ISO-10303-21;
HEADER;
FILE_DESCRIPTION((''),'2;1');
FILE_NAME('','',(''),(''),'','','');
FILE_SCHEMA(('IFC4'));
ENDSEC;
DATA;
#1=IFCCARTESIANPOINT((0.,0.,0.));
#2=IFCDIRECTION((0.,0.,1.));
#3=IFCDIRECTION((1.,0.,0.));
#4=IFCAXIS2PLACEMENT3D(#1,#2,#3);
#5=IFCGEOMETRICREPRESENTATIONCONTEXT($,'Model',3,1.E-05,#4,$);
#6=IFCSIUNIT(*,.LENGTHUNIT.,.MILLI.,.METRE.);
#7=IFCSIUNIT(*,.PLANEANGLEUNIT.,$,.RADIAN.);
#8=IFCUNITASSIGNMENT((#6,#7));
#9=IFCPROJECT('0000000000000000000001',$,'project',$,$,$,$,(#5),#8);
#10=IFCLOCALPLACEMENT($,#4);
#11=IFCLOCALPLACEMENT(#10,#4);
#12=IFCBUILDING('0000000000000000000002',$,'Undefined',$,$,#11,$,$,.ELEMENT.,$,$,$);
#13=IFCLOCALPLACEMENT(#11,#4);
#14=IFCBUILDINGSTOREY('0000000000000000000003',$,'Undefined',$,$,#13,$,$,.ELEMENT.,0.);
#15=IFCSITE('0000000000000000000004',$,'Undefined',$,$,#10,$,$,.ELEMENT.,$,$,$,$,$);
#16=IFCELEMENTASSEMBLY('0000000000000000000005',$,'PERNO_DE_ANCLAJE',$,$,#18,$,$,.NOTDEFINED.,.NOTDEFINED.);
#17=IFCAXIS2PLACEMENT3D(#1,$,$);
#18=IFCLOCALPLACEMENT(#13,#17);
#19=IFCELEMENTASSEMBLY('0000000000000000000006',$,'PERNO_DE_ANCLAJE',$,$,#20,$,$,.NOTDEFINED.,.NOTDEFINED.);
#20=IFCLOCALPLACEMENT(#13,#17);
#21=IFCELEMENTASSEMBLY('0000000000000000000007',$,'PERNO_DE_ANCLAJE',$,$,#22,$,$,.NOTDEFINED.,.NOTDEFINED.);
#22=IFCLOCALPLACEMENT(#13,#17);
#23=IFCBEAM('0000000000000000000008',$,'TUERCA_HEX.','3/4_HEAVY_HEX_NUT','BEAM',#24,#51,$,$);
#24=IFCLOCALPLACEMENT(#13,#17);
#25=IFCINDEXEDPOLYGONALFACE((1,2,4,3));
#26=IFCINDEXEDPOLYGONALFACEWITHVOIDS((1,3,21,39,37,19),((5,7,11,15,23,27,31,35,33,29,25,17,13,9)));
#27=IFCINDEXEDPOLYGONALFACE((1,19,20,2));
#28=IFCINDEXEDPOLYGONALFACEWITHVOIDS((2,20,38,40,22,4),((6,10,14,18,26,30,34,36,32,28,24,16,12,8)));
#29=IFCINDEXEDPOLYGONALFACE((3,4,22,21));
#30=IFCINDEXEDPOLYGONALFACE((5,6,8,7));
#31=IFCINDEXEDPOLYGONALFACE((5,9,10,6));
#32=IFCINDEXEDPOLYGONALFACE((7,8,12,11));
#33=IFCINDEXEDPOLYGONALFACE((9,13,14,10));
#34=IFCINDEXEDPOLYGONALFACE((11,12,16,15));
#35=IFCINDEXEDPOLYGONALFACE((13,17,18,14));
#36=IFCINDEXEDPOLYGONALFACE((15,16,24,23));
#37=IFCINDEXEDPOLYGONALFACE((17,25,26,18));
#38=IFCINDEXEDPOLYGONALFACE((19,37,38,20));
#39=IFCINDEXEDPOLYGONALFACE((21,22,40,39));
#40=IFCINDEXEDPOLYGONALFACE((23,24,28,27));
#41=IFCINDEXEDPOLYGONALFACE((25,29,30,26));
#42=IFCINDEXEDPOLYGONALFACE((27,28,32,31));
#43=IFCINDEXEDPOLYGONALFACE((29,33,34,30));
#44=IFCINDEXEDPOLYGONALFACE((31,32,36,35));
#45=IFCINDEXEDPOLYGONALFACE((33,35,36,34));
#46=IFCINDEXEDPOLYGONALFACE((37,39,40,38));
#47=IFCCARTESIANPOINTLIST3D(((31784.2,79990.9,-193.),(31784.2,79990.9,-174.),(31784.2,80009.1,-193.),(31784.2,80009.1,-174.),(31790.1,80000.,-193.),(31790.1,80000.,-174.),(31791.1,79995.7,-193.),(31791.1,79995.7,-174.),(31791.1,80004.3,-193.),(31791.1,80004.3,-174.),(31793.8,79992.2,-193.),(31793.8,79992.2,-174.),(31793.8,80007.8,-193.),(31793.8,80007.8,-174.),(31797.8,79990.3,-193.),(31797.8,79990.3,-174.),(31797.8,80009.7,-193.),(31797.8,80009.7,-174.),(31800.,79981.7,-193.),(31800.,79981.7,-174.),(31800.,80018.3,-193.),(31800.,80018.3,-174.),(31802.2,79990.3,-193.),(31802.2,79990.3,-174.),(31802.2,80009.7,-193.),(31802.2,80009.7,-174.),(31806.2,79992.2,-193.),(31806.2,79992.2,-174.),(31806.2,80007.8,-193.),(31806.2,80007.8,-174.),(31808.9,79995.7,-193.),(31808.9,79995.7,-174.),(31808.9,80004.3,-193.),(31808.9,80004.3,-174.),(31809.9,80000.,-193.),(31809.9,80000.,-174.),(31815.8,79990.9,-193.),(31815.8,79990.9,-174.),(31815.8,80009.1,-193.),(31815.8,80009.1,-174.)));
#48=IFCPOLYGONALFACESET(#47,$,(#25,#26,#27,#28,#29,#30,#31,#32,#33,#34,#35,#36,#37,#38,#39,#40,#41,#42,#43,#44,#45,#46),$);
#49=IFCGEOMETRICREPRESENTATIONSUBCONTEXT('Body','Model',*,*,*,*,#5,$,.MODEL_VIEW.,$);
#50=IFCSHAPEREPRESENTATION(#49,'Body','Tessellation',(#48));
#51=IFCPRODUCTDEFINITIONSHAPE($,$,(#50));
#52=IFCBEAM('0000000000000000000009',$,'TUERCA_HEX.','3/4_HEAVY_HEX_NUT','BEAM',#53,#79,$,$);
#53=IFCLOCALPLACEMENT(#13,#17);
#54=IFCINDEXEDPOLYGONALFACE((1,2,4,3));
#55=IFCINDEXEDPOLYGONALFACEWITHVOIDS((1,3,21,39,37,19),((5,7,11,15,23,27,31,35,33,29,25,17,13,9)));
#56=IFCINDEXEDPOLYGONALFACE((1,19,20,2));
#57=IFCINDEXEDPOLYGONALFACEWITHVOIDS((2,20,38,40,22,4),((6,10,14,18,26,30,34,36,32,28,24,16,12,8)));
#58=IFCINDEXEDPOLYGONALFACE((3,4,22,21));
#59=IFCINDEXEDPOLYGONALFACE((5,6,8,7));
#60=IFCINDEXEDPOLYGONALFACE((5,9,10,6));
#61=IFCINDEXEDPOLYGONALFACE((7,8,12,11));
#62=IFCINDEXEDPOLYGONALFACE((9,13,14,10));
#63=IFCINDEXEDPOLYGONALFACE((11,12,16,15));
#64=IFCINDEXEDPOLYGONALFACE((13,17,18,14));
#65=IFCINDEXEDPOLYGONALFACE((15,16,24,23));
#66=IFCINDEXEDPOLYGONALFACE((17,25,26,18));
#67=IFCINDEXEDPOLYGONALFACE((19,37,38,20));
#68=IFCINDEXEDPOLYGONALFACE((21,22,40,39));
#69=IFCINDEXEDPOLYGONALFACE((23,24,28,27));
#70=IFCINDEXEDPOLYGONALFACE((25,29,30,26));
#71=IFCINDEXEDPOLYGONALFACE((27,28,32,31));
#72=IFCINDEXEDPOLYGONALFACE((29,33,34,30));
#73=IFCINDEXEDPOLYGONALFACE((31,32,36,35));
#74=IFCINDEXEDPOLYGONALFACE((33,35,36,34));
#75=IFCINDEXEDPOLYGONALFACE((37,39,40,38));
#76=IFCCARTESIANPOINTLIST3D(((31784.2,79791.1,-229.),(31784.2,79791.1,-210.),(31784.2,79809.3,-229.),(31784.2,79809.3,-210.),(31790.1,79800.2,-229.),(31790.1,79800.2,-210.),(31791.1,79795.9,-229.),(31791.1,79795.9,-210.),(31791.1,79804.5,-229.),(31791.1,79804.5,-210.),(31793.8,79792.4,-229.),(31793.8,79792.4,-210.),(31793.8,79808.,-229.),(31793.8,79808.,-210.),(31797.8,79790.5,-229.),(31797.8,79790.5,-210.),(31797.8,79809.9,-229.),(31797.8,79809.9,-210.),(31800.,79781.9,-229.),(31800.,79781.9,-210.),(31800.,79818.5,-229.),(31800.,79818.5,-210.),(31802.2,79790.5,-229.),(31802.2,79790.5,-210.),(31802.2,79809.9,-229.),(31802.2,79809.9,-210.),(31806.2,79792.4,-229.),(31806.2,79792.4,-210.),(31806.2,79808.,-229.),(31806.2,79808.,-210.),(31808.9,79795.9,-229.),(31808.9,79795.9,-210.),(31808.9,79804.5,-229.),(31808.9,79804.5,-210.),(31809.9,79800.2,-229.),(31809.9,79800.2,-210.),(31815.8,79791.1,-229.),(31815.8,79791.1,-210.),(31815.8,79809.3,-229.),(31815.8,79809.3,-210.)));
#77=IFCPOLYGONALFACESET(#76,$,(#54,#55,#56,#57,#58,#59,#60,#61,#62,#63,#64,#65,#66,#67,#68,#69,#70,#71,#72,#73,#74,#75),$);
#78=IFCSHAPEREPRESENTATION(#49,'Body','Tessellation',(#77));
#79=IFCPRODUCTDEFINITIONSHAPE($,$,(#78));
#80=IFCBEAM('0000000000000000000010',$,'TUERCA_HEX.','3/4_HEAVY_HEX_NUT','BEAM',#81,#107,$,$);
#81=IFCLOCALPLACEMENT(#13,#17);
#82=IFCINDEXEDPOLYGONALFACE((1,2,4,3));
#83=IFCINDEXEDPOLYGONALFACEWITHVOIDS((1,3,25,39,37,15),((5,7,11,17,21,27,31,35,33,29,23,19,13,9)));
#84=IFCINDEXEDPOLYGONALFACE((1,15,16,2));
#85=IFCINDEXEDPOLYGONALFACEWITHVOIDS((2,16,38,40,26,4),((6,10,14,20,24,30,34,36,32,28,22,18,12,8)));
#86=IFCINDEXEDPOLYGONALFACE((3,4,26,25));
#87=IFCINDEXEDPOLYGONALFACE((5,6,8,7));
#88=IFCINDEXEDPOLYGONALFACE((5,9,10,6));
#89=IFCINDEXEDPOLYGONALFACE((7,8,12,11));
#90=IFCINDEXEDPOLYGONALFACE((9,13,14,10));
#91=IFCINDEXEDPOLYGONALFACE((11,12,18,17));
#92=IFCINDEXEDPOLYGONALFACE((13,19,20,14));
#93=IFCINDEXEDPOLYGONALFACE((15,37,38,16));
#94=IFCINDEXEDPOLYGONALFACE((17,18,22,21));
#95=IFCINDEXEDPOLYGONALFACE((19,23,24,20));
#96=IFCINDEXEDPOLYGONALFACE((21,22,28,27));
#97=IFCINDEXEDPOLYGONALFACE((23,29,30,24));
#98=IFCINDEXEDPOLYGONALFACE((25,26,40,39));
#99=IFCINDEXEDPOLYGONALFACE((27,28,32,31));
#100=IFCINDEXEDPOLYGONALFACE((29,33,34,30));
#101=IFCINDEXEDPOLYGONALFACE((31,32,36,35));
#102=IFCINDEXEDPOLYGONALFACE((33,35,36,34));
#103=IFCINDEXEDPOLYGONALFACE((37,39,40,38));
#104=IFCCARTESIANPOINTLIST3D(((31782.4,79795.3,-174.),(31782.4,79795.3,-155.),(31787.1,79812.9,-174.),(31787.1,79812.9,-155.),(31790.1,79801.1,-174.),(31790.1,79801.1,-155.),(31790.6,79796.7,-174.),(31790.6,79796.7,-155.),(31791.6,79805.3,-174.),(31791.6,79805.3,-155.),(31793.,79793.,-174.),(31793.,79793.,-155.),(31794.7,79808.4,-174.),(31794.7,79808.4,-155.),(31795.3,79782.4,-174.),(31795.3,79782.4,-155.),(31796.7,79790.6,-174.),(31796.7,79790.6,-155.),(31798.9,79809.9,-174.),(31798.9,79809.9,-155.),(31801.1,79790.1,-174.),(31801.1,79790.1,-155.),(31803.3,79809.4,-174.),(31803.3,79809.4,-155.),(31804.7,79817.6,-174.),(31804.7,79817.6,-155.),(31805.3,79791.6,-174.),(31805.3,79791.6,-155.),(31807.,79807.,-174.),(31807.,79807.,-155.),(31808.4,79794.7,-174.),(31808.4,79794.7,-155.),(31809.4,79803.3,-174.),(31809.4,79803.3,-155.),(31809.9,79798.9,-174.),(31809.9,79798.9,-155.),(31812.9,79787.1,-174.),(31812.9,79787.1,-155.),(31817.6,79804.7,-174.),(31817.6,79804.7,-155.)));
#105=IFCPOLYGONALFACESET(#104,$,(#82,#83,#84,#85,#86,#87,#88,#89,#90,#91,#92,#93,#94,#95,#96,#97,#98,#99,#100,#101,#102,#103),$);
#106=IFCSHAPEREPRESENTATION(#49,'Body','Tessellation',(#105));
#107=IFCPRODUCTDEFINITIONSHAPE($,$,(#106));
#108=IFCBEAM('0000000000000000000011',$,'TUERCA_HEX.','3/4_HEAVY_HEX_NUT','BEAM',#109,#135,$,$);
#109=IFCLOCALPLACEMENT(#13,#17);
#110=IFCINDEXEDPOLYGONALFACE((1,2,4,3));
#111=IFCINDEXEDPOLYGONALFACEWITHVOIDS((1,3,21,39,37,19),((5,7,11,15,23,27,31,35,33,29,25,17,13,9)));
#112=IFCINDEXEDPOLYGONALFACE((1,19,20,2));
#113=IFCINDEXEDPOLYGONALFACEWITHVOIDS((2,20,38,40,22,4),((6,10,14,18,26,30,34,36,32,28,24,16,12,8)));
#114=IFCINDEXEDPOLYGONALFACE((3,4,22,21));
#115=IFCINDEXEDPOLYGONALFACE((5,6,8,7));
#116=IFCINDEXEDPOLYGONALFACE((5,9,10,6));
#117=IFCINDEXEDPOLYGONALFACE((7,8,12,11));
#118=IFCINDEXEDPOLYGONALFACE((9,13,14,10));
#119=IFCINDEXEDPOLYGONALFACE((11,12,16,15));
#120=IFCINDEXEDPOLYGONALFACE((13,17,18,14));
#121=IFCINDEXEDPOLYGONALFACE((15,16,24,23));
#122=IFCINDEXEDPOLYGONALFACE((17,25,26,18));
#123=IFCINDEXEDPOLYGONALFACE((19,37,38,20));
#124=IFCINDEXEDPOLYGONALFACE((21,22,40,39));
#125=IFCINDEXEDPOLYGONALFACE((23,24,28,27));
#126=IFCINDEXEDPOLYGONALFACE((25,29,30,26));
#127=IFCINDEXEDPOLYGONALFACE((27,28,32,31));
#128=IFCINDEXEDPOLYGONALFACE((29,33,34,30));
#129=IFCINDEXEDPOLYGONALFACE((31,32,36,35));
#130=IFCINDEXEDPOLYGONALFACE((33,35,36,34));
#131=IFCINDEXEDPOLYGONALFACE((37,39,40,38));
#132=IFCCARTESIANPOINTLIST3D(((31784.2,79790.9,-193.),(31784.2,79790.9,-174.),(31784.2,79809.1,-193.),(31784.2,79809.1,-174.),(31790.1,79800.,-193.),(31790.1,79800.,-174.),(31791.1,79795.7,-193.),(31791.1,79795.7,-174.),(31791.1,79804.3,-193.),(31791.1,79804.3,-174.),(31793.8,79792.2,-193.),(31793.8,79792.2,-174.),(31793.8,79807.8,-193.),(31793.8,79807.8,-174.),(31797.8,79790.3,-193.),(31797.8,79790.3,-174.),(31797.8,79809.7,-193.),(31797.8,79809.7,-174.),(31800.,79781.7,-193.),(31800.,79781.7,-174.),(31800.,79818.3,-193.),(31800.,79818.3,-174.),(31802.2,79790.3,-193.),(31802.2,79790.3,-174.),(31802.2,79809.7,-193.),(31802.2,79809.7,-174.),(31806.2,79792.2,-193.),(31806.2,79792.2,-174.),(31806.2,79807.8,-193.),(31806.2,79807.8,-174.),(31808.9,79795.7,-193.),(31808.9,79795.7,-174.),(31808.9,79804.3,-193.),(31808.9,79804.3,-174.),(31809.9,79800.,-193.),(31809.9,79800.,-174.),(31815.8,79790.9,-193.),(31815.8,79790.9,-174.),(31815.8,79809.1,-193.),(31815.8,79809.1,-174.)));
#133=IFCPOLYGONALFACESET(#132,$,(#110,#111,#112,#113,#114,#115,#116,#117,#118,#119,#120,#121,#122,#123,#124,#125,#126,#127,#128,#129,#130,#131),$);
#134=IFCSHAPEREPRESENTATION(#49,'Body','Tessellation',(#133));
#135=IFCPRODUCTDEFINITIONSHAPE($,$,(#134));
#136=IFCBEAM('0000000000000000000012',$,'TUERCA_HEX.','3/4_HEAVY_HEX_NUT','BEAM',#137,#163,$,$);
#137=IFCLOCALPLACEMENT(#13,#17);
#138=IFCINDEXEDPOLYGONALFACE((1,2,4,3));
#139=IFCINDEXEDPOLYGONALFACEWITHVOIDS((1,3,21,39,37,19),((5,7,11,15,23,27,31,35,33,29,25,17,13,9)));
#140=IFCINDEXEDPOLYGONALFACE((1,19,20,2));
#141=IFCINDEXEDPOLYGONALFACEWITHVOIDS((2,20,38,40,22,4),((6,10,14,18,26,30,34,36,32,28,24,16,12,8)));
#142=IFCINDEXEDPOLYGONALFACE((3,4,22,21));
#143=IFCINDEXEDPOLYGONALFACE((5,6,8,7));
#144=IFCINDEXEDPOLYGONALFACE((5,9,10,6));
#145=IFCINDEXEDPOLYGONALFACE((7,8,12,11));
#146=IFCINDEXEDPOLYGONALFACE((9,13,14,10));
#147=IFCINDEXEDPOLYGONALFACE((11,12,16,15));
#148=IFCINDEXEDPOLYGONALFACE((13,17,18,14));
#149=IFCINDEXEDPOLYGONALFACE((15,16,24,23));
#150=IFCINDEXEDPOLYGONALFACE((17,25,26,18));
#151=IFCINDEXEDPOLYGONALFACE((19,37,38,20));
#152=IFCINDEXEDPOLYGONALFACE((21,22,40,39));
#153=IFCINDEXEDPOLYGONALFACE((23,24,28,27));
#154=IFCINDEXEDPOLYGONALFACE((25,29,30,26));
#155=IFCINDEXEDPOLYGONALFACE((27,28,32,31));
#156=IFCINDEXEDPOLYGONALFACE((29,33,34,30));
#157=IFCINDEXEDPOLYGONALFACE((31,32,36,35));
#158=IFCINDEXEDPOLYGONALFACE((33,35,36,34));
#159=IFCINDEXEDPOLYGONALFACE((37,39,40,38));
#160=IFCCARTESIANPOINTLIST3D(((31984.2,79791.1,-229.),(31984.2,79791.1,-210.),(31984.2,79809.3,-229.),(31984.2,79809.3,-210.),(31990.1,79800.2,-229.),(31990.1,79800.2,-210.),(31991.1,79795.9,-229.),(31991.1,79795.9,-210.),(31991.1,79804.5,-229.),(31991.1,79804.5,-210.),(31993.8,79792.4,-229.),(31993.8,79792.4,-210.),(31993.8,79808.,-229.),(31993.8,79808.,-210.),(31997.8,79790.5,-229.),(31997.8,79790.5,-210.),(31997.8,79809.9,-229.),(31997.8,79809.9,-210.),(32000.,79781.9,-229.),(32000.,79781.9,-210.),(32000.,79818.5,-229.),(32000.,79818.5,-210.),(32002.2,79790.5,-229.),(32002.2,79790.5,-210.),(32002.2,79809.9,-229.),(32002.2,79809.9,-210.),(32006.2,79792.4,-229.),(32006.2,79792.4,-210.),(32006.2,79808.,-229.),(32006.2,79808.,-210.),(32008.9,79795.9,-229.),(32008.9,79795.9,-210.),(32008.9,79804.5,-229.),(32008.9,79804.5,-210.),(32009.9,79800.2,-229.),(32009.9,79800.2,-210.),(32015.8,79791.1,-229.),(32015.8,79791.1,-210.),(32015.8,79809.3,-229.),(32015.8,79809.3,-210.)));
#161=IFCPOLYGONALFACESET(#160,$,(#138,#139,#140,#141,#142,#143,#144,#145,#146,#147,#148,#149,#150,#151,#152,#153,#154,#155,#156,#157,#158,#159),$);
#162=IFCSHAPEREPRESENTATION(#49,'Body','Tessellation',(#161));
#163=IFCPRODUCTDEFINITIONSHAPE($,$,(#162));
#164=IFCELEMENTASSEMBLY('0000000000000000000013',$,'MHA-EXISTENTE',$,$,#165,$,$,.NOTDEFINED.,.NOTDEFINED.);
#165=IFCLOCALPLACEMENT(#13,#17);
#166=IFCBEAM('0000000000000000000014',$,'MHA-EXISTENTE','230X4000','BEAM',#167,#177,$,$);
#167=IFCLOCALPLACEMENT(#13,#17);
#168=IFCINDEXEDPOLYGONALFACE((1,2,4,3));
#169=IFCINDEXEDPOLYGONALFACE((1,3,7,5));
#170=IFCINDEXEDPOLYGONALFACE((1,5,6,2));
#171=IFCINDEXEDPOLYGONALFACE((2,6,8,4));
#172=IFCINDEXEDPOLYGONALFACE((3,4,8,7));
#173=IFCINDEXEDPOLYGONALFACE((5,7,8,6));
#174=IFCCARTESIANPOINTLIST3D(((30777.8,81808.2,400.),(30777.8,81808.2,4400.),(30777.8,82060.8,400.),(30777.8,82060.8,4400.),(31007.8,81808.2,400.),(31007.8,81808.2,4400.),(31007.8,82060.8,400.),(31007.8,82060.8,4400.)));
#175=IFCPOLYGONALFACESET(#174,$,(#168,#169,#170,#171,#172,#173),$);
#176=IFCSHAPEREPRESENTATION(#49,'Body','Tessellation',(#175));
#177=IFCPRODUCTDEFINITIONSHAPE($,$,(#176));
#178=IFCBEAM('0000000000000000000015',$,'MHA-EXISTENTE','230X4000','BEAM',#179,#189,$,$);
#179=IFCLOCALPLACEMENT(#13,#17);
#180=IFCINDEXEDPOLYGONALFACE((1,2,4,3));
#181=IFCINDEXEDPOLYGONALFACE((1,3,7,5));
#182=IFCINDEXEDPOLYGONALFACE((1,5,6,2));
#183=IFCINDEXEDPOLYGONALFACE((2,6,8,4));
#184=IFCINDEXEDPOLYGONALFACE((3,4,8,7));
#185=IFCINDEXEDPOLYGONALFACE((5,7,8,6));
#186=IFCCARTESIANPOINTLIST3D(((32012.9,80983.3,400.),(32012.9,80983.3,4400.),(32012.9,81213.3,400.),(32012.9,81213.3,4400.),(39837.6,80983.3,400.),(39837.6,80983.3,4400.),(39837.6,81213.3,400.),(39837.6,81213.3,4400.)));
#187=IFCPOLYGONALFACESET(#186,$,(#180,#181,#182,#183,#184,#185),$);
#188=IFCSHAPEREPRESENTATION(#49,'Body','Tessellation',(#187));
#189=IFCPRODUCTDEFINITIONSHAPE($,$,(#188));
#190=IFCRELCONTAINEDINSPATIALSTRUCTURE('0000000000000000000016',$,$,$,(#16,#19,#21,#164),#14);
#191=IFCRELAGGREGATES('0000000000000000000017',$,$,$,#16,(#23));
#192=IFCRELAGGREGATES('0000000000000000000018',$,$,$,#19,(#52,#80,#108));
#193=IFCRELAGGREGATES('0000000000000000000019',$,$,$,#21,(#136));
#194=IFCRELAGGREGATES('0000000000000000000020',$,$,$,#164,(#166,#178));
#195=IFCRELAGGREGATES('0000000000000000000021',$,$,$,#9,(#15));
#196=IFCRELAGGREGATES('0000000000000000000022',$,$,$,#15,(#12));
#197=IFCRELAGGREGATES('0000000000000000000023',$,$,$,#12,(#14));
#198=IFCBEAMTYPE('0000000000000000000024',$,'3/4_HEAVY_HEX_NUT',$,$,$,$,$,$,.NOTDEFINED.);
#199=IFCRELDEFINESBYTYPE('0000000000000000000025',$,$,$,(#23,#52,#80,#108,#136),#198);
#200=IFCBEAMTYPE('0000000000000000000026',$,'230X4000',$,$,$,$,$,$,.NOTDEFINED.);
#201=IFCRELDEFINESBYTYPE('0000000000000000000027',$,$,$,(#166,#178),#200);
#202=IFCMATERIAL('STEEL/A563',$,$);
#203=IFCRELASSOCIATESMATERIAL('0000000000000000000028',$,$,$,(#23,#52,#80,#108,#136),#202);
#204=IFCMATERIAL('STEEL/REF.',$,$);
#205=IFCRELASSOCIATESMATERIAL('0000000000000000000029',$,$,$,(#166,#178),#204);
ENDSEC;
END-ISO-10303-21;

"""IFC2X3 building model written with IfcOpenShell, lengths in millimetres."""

from ifc_helpers import new_model, si_unit, frame, origin_with_axes, origin_2d_with_axis, place, context, subcontext, project, spatial, polyline, rectangle, outline, extrude, material, type_object, element, aggregate, save


model = new_model("IFC2X3")

# Units and contexts
model_context = context("Model", 3, precision=1e-05, world=origin_with_axes())
body_context = subcontext(model_context, "Body", "Model", "MODEL_VIEW")
ifc_project = project(units=[si_unit("LENGTHUNIT", "METRE", prefix="MILLI"), si_unit("PLANEANGLEUNIT", "RADIAN")], contexts=[model_context])

# Site, building, storey
site_placement = place(None, origin_with_axes())
site = spatial("IfcSite", under=ifc_project, at=site_placement, Name="Undefined", CompositionType="ELEMENT")
building_placement = place(site_placement, origin_with_axes())
building = spatial("IfcBuilding", under=site, at=building_placement, Name="Undefined", CompositionType="ELEMENT")
storey_placement = place(building_placement, origin_with_axes())
storey = spatial("IfcBuildingStorey", under=building, at=storey_placement, Name="Undefined", CompositionType="ELEMENT", Elevation=0.0)

# Element assemblies
ifc_material_1 = material(Name="STEEL/A563")
assembly_1_placement = place(storey_placement, origin_with_axes())
assembly_1 = element("IfcElementAssembly", 1, at=assembly_1_placement, inside=storey, Name="PERNO_DE_ANCLAJE", AssemblyPlace="NOTDEFINED", PredefinedType="NOTDEFINED")
assembly_2_placement = place(storey_placement, origin_with_axes())
assembly_2 = element("IfcElementAssembly", 2, at=assembly_2_placement, inside=storey, Name="PERNO_DE_ANCLAJE", AssemblyPlace="NOTDEFINED", PredefinedType="NOTDEFINED")
assembly_3_placement = place(storey_placement, origin_with_axes())
assembly_3 = element("IfcElementAssembly", 3, at=assembly_3_placement, inside=storey, Name="PERNO_DE_ANCLAJE", AssemblyPlace="NOTDEFINED", PredefinedType="NOTDEFINED")

# Beams
beam_type_1 = type_object("IfcBeamType", Name="3/4_HEAVY_HEX_NUT", PredefinedType="NOTDEFINED")
beam_1_placement = place(assembly_1_placement, frame((31800.0, 80000.0, -174.0), z_axis=(1.0, 0.0, 0.0), x_axis=(0.0, 0.0, -1.0)))
beam_1 = element("IfcBeam", 4, at=beam_1_placement, type_object=beam_type_1, material=ifc_material_1, Name="TUERCA_HEX.", Description="3/4_HEAVY_HEX_NUT", ObjectType="BEAM", context=body_context, shape_type="SweptSolid", body=[
    extrude(outline(polyline([(-9.1, -15.8), (-18.3, 0.0), (-9.1, 15.8), (9.1, 15.8), (18.3, 0.0), (9.1, -15.8), (-9.1, -15.8)]), holes=[polyline([(7.8, 6.2), (4.3, 8.9), (0.0, 9.9), (-4.3, 8.9), (-7.8, 6.2), (-9.7, 2.2), (-9.7, -2.2), (-7.8, -6.2), (-4.3, -8.9), (0.0, -9.9), (4.3, -8.9), (7.8, -6.2), (9.7, -2.2), (9.7, 2.2), (7.8, 6.2)])]), frame((19.0, 0.0, 0.0), z_axis=(-1.0, 0.0, 0.0), x_axis=(0.0, -1.0, 0.0)), (0.0, 0.0, 1.0), 19.0),
])
aggregate(assembly_1, [beam_1])
beam_2_placement = place(assembly_2_placement, frame((31800.0, 79800.2, -210.0), z_axis=(1.0, 0.0, 0.0), x_axis=(0.0, 0.0, -1.0)))
beam_2 = element("IfcBeam", 5, at=beam_2_placement, type_object=beam_type_1, material=ifc_material_1, Name="TUERCA_HEX.", Description="3/4_HEAVY_HEX_NUT", ObjectType="BEAM", context=body_context, shape_type="SweptSolid", body=[
    extrude(outline(polyline([(-9.1, -15.8), (-18.3, 0.0), (-9.1, 15.8), (9.1, 15.8), (18.3, 0.0), (9.1, -15.8), (-9.1, -15.8)]), holes=[polyline([(7.8, 6.2), (4.3, 8.9), (0.0, 9.9), (-4.3, 8.9), (-7.8, 6.2), (-9.7, 2.2), (-9.7, -2.2), (-7.8, -6.2), (-4.3, -8.9), (0.0, -9.9), (4.3, -8.9), (7.8, -6.2), (9.7, -2.2), (9.7, 2.2), (7.8, 6.2)])]), frame((19.0, 0.0, 0.0), z_axis=(-1.0, 0.0, 0.0), x_axis=(0.0, -1.0, 0.0)), (0.0, 0.0, 1.0), 19.0),
])
beam_3_placement = place(assembly_2_placement, frame((31800.0, 79800.0, -155.0), z_axis=(0.707107, 0.707107, 0.0), x_axis=(0.0, 0.0, -1.0)))
beam_3 = element("IfcBeam", 6, at=beam_3_placement, type_object=beam_type_1, material=ifc_material_1, Name="TUERCA_HEX.", Description="3/4_HEAVY_HEX_NUT", ObjectType="BEAM", context=body_context, shape_type="SweptSolid", body=[
    extrude(outline(polyline([(-9.1, -15.8), (-18.3, 0.0), (-9.1, 15.8), (9.1, 15.8), (18.3, 0.0), (9.1, -15.8), (-9.1, -15.8)]), holes=[polyline([(7.8, 6.2), (4.3, 8.9), (0.0, 9.9), (-4.3, 8.9), (-7.8, 6.2), (-9.7, 2.2), (-9.7, -2.2), (-7.8, -6.2), (-4.3, -8.9), (0.0, -9.9), (4.3, -8.9), (7.8, -6.2), (9.7, -2.2), (9.7, 2.2), (7.8, 6.2)])]), frame((19.0, 0.0, 0.0), z_axis=(-1.0, 0.0, 0.0), x_axis=(0.0, -1.0, 0.0)), (0.0, 0.0, 1.0), 19.0),
])
beam_4_placement = place(assembly_2_placement, frame((31800.0, 79800.0, -174.0), z_axis=(1.0, 0.0, 0.0), x_axis=(0.0, 0.0, -1.0)))
beam_4 = element("IfcBeam", 7, at=beam_4_placement, type_object=beam_type_1, material=ifc_material_1, Name="TUERCA_HEX.", Description="3/4_HEAVY_HEX_NUT", ObjectType="BEAM", context=body_context, shape_type="SweptSolid", body=[
    extrude(outline(polyline([(-9.1, -15.8), (-18.3, 0.0), (-9.1, 15.8), (9.1, 15.8), (18.3, 0.0), (9.1, -15.8), (-9.1, -15.8)]), holes=[polyline([(7.8, 6.2), (4.3, 8.9), (0.0, 9.9), (-4.3, 8.9), (-7.8, 6.2), (-9.7, 2.2), (-9.7, -2.2), (-7.8, -6.2), (-4.3, -8.9), (0.0, -9.9), (4.3, -8.9), (7.8, -6.2), (9.7, -2.2), (9.7, 2.2), (7.8, 6.2)])]), frame((19.0, 0.0, 0.0), z_axis=(-1.0, 0.0, 0.0), x_axis=(0.0, -1.0, 0.0)), (0.0, 0.0, 1.0), 19.0),
])
aggregate(assembly_2, [beam_2, beam_3, beam_4])
beam_5_placement = place(assembly_3_placement, frame((32000.0, 79800.2, -210.0), z_axis=(1.0, 0.0, 0.0), x_axis=(0.0, 0.0, -1.0)))
beam_5 = element("IfcBeam", 8, at=beam_5_placement, type_object=beam_type_1, material=ifc_material_1, Name="TUERCA_HEX.", Description="3/4_HEAVY_HEX_NUT", ObjectType="BEAM", context=body_context, shape_type="SweptSolid", body=[
    extrude(outline(polyline([(-9.1, -15.8), (-18.3, 0.0), (-9.1, 15.8), (9.1, 15.8), (18.3, 0.0), (9.1, -15.8), (-9.1, -15.8)]), holes=[polyline([(7.8, 6.2), (4.3, 8.9), (0.0, 9.9), (-4.3, 8.9), (-7.8, 6.2), (-9.7, 2.2), (-9.7, -2.2), (-7.8, -6.2), (-4.3, -8.9), (0.0, -9.9), (4.3, -8.9), (7.8, -6.2), (9.7, -2.2), (9.7, 2.2), (7.8, 6.2)])]), frame((19.0, 0.0, 0.0), z_axis=(-1.0, 0.0, 0.0), x_axis=(0.0, -1.0, 0.0)), (0.0, 0.0, 1.0), 19.0),
])
aggregate(assembly_3, [beam_5])

# Shared definitions
ifc_material_2 = material(Name="STEEL/REF.")

# Element assembly, beams
assembly_4_placement = place(storey_placement, origin_with_axes())
assembly_4 = element("IfcElementAssembly", 9, at=assembly_4_placement, inside=storey, Name="MHA-EXISTENTE", AssemblyPlace="NOTDEFINED", PredefinedType="NOTDEFINED")
beam_type_2 = type_object("IfcBeamType", Name="230X4000", PredefinedType="NOTDEFINED")
beam_6_placement = place(assembly_4_placement, frame((30892.8, 82060.8, 2400.0), z_axis=(1.0, -0.000049, 0.0), x_axis=(-0.000049, -1.0, 0.0)))
beam_6 = element("IfcBeam", 10, at=beam_6_placement, type_object=beam_type_2, material=ifc_material_2, Name="MHA-EXISTENTE", Description="230X4000", ObjectType="BEAM", context=body_context, shape_type="SweptSolid", body=[
    extrude(rectangle(XDim=4000.0, YDim=230.0, at=origin_2d_with_axis()), frame((252.7, 0.0, 0.0), z_axis=(-1.0, 0.0, 0.0), x_axis=(0.0, -1.0, 0.0)), (0.0, 0.0, 1.0), 252.7),
])
beam_7_placement = place(assembly_4_placement, frame((32012.9, 81098.3, 2400.0), z_axis=(0.0, 1.0, 0.0), x_axis=(1.0, 0.0, 0.0)))
beam_7 = element("IfcBeam", 11, at=beam_7_placement, type_object=beam_type_2, material=ifc_material_2, Name="MHA-EXISTENTE", Description="230X4000", ObjectType="BEAM", context=body_context, shape_type="SweptSolid", body=[
    extrude(rectangle(XDim=4000.0, YDim=230.0, at=origin_2d_with_axis()), frame((7824.7, 0.0, 0.0), z_axis=(-1.0, 0.0, 0.0), x_axis=(0.0, -1.0, 0.0)), (0.0, 0.0, 1.0), 7824.7),
])
aggregate(assembly_4, [beam_6, beam_7])

save(model, "model.ifc")
